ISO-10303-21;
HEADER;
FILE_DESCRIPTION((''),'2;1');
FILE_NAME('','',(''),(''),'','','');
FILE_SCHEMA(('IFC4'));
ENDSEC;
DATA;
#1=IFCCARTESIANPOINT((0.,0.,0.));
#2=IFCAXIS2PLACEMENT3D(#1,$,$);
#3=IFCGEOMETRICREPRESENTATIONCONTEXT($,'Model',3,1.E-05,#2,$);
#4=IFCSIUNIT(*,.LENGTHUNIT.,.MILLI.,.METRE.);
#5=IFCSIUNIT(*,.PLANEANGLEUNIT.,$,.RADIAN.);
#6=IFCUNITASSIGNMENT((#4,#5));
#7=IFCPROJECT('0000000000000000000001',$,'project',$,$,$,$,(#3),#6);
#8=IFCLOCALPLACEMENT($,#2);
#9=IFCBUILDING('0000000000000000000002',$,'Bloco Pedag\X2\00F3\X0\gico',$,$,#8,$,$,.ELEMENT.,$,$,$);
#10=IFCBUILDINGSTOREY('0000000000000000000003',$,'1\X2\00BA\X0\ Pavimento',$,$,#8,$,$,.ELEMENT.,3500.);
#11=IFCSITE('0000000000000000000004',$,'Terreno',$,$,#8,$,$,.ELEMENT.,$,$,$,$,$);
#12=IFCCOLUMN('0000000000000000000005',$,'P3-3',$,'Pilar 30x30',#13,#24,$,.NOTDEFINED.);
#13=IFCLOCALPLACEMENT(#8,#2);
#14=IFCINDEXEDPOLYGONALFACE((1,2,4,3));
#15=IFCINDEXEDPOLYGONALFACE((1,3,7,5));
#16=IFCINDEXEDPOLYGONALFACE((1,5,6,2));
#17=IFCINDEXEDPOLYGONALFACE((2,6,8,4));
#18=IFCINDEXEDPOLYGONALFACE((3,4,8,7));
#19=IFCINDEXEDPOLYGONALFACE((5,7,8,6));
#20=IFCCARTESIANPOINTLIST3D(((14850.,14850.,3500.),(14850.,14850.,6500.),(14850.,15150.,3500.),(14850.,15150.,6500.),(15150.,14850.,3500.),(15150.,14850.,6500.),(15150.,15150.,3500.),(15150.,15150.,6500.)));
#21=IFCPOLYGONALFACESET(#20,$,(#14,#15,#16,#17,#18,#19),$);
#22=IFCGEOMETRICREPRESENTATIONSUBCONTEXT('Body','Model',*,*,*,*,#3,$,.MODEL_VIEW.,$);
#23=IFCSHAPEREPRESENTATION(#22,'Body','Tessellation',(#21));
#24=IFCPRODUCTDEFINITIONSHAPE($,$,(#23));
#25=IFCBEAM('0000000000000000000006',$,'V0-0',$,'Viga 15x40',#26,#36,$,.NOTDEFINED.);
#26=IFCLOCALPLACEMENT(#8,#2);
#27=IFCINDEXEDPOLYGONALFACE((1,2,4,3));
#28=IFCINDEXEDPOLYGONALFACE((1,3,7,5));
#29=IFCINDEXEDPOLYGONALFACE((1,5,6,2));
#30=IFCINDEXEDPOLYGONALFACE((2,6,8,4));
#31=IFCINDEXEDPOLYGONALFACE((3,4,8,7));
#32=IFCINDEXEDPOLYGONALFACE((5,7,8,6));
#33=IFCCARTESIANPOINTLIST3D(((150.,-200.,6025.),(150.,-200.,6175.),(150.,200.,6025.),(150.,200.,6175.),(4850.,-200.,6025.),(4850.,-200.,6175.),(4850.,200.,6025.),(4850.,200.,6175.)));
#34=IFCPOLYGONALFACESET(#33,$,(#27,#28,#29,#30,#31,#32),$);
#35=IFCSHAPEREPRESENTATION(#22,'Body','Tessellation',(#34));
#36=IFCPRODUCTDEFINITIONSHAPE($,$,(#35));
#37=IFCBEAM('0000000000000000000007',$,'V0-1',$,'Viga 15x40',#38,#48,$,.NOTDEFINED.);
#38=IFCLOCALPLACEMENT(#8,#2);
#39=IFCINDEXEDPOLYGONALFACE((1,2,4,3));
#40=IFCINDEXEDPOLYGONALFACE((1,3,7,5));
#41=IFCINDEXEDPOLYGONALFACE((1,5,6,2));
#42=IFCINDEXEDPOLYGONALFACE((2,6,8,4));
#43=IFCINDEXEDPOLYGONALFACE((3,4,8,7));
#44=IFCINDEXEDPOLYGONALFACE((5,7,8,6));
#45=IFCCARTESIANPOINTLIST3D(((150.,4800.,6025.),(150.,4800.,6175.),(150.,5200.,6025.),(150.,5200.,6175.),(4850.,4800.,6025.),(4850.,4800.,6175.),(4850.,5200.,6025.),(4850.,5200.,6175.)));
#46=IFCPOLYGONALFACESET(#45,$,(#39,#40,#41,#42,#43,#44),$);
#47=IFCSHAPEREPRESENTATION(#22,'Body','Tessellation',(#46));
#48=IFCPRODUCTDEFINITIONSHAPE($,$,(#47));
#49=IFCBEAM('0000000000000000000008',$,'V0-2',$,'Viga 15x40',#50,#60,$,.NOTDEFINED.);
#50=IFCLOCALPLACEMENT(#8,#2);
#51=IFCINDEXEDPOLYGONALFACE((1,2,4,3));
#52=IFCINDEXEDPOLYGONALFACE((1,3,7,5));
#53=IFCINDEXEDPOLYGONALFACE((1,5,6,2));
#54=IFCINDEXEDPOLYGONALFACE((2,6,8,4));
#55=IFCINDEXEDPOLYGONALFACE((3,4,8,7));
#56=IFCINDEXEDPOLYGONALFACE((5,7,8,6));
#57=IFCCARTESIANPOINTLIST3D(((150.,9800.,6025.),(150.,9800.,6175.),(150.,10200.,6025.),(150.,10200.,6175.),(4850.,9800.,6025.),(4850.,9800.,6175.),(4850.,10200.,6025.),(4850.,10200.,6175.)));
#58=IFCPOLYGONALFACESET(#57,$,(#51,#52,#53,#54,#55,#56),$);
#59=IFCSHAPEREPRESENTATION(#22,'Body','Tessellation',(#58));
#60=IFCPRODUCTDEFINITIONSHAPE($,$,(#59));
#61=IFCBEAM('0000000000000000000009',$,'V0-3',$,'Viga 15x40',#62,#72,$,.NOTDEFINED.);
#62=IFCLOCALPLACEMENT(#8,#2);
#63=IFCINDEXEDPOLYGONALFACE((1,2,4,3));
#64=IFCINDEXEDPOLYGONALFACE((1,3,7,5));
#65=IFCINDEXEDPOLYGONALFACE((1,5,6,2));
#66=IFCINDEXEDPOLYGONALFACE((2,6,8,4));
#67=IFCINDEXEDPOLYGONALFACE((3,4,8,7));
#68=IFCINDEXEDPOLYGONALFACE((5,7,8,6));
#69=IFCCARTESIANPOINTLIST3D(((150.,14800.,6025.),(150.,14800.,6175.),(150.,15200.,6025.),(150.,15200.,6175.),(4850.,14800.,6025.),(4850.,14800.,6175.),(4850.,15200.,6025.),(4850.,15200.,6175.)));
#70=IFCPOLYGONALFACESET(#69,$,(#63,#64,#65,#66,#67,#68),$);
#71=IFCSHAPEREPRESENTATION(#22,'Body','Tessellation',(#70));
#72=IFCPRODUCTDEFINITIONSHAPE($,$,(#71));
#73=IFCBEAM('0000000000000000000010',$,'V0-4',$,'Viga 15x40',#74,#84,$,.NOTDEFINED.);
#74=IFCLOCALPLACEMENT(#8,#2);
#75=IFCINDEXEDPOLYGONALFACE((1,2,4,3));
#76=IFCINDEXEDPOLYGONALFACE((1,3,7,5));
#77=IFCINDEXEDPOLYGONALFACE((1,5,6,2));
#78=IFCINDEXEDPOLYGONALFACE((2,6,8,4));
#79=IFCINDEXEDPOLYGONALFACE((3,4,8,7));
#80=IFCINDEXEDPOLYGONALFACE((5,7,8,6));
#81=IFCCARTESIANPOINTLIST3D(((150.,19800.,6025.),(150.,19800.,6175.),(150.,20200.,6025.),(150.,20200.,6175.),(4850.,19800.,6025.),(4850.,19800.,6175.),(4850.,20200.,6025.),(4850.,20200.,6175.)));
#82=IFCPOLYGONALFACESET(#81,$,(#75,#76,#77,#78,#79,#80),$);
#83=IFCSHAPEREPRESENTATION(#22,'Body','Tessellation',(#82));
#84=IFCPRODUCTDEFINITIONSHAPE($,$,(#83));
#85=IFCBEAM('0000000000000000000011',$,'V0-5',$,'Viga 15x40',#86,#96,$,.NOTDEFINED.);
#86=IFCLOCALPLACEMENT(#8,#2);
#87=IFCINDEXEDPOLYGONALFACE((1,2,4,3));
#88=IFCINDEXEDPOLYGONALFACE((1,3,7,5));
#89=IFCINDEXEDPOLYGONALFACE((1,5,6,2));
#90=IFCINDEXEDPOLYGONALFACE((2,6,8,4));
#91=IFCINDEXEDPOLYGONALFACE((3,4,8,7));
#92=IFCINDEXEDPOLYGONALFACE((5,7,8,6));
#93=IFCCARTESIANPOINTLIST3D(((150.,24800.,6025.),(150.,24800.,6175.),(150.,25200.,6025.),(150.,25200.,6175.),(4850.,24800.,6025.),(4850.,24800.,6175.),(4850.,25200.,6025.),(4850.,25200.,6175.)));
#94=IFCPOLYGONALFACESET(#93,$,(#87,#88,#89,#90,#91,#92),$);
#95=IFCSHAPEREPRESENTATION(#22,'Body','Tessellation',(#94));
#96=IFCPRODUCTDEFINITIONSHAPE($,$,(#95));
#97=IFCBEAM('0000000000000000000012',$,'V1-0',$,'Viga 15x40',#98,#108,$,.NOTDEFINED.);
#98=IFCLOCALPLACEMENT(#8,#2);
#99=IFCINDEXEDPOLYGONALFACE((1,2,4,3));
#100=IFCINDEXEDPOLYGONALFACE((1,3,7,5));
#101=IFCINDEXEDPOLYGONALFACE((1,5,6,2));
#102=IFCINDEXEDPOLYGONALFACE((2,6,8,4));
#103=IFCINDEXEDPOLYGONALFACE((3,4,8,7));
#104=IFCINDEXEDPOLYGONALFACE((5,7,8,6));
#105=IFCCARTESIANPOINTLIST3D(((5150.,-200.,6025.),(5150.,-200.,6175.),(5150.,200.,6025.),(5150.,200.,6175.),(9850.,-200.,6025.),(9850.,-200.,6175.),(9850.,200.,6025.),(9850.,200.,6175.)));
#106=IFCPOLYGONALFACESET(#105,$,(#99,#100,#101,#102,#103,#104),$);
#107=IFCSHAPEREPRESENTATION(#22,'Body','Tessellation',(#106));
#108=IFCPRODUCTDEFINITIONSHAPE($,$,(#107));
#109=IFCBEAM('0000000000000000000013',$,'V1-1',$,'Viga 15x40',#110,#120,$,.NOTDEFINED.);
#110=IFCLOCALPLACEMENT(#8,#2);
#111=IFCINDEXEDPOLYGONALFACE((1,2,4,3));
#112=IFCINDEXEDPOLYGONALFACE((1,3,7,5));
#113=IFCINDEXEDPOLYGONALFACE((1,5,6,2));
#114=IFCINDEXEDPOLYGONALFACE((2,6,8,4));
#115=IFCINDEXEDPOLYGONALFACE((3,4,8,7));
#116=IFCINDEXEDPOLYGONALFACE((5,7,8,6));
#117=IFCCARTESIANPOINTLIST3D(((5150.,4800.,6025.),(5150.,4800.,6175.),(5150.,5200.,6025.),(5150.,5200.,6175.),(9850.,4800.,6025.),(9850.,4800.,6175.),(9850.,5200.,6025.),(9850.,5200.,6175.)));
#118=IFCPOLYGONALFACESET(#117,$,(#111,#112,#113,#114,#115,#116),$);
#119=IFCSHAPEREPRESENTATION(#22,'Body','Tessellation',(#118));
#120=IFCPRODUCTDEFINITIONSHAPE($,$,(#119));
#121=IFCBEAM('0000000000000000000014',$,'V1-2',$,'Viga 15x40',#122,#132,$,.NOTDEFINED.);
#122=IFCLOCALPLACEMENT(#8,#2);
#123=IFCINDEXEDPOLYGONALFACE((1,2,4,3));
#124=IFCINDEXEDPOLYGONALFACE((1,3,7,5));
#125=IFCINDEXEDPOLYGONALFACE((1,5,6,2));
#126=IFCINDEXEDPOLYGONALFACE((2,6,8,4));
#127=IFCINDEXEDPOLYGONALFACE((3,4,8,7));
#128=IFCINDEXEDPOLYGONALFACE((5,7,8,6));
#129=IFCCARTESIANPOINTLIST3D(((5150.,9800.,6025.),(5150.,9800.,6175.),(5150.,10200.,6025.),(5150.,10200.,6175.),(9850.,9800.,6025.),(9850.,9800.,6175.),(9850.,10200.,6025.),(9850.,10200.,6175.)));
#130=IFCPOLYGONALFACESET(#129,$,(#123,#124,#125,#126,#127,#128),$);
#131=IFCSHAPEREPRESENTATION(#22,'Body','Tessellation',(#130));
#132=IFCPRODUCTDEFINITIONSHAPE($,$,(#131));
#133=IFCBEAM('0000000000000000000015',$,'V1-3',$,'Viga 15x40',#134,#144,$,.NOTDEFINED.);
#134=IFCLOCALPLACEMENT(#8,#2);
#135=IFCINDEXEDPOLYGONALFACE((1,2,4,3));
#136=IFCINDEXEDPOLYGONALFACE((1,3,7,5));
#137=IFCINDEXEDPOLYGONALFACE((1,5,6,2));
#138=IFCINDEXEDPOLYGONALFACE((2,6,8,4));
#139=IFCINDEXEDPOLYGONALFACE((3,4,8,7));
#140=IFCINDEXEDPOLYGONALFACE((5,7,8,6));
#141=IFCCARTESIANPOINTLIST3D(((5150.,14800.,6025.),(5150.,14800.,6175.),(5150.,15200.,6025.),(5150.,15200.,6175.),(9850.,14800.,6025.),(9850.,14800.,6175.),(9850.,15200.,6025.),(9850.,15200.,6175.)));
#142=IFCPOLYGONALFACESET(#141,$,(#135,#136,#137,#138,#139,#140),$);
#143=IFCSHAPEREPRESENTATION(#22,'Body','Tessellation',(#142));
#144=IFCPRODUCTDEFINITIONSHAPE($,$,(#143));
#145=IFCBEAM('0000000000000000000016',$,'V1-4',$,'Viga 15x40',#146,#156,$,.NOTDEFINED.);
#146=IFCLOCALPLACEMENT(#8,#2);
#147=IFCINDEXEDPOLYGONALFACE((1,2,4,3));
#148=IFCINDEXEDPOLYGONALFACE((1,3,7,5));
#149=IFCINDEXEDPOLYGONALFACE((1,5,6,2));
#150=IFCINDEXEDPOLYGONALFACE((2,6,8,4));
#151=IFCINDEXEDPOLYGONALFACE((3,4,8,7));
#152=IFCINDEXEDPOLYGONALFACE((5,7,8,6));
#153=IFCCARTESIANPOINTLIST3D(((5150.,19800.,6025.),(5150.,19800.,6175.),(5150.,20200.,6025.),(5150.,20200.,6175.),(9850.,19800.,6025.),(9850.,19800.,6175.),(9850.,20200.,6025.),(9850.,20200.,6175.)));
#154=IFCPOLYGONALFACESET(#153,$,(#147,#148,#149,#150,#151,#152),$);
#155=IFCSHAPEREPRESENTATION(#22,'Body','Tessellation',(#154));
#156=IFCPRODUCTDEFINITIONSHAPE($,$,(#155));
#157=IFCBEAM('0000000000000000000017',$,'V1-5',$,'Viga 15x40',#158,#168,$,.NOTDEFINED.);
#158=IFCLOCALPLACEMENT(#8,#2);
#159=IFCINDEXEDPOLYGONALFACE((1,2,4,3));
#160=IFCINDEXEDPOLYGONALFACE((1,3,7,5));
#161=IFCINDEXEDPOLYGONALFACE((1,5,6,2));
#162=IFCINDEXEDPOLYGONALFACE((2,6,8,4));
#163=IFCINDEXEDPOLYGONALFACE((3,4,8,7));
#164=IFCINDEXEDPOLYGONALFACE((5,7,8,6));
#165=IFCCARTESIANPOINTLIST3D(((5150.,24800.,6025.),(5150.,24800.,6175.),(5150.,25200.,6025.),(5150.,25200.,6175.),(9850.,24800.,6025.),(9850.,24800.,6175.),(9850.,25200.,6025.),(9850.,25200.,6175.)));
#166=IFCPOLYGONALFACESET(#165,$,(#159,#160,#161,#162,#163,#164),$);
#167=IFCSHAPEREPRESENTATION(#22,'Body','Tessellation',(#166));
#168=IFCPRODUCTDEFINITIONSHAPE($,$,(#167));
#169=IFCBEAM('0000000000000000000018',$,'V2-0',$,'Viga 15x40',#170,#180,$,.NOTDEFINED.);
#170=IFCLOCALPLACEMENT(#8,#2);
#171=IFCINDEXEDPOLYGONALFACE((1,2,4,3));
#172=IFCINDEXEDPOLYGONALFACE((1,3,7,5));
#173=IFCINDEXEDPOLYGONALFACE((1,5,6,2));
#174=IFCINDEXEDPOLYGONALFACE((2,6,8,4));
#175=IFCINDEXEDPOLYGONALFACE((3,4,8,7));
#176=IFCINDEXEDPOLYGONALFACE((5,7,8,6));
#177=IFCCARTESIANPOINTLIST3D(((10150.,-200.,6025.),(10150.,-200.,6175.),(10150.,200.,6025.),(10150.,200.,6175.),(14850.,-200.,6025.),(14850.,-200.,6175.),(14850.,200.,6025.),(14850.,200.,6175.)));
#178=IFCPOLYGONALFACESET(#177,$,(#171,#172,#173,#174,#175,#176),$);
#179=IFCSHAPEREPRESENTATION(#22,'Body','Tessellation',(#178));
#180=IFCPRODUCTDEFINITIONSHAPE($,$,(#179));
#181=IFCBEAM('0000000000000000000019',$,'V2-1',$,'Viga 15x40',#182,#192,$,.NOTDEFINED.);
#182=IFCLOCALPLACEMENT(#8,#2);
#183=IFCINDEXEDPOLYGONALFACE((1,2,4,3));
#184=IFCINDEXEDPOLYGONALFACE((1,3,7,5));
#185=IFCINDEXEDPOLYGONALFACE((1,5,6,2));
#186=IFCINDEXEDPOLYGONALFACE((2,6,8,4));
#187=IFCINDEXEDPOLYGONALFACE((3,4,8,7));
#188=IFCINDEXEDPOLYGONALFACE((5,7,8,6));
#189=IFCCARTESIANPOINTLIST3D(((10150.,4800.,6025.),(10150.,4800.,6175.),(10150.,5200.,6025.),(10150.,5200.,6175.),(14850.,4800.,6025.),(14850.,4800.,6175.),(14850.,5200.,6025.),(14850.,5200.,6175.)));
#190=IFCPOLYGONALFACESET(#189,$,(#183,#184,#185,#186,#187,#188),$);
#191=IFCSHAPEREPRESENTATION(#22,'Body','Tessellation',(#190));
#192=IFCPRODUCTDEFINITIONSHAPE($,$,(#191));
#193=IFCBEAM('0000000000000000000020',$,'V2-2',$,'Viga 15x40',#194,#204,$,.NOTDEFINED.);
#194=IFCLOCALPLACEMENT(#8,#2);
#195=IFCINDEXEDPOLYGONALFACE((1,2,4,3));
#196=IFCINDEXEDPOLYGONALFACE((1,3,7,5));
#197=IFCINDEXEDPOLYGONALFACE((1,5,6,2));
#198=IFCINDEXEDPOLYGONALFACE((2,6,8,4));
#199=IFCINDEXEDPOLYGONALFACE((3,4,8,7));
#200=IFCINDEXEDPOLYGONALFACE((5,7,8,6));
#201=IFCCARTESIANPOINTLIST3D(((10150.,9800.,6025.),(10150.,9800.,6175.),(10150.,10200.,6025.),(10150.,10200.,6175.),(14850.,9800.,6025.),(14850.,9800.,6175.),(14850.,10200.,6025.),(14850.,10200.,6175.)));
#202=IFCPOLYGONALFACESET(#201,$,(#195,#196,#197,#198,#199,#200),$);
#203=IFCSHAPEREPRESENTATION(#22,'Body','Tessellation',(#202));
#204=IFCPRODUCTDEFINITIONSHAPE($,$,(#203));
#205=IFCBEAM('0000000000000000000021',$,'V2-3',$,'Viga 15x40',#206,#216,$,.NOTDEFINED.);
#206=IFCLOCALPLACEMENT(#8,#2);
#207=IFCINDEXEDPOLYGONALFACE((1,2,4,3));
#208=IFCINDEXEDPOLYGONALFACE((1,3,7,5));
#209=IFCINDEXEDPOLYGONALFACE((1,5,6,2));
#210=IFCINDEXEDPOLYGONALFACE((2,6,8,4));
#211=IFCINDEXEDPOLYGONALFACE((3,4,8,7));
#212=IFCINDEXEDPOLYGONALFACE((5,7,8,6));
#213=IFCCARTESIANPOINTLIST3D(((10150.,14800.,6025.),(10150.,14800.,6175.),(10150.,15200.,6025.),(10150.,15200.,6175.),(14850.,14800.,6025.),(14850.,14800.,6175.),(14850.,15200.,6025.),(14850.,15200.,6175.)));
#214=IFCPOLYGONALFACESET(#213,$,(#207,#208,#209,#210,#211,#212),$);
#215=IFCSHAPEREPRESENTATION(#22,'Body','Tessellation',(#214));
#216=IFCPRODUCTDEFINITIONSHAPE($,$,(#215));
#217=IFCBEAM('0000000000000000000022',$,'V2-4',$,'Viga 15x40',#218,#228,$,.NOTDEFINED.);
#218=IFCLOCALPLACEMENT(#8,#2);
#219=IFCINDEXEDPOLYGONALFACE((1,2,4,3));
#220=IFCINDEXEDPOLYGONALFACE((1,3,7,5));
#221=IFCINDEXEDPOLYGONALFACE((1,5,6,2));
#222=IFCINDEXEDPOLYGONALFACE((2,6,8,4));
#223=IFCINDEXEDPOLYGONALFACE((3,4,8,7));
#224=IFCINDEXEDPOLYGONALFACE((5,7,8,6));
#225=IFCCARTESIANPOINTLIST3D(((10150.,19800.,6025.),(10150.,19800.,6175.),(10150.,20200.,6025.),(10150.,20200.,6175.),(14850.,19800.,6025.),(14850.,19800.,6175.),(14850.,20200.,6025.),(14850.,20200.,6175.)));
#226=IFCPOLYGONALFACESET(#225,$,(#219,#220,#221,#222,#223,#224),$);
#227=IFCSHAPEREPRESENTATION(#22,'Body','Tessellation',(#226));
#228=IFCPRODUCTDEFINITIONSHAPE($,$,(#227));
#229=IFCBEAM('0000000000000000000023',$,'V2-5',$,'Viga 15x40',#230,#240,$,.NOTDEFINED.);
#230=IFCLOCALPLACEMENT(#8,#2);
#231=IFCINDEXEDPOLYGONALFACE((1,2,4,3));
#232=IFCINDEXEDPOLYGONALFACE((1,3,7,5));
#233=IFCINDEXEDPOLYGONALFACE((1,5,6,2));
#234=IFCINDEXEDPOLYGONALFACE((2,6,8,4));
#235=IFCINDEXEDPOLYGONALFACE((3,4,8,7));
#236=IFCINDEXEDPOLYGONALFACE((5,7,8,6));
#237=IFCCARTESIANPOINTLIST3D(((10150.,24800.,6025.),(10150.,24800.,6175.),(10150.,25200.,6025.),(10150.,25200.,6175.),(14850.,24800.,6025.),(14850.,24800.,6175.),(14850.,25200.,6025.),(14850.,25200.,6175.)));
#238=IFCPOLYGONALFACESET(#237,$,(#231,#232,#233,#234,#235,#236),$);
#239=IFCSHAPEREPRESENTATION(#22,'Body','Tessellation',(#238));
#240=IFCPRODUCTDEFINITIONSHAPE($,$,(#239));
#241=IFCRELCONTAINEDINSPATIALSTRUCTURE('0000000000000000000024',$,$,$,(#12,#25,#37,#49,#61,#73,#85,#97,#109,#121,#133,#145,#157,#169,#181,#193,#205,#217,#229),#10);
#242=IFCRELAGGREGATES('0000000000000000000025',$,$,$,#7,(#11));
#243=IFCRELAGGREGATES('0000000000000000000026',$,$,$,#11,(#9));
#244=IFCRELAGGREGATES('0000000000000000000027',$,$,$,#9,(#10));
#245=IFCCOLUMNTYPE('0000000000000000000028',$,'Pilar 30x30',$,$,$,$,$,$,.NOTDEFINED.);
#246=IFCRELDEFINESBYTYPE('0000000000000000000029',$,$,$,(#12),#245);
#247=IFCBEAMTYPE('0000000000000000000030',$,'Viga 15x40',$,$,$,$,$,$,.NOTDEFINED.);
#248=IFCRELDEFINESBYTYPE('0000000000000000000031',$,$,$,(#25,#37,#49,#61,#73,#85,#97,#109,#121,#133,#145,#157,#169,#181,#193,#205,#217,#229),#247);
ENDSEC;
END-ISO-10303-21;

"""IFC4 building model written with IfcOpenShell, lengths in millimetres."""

from ifc_helpers import new_model, si_unit, frame, origin, origin_2d, place, context, subcontext, project, spatial, rectangle, extrude, type_object, element, save


model = new_model("IFC4")

# Units and contexts
model_context = context("Model", 3, precision=1e-05, world=origin())
body_context = subcontext(model_context, "Body", "Model", "MODEL_VIEW")
ifc_project = project(units=[si_unit("LENGTHUNIT", "METRE", prefix="MILLI"), si_unit("PLANEANGLEUNIT", "RADIAN")], contexts=[model_context])

# Site, building, storey
placement = place(None, origin())
site = spatial("IfcSite", under=ifc_project, at=placement, Name="Terreno", CompositionType="ELEMENT")
building = spatial("IfcBuilding", under=site, at=placement, Name="Bloco Pedagógico", CompositionType="ELEMENT")
storey = spatial("IfcBuildingStorey", under=building, at=placement, Name="1º Pavimento", CompositionType="ELEMENT", Elevation=3500.0)

# Column
column_type = type_object("IfcColumnType", Name="Pilar 30x30", PredefinedType="NOTDEFINED")
for number, where, z_axis, x_axis, name in (
    (1, (15000.0, 15000.0, 3500.0), (0.0, 0.0, 1.0), (1.0, 0.0, 0.0), "P3-3"),
):
    element("IfcColumn", number, at=place(None, frame(where, z_axis=z_axis, x_axis=x_axis)), inside=storey, type_object=column_type, Name=name, ObjectType="Pilar 30x30", PredefinedType="NOTDEFINED", context=body_context, shape_type="SweptSolid", body=[
        extrude(rectangle(XDim=300.0, YDim=300.0, at=origin_2d()), None, (0.0, 0.0, 1.0), 3000.0),
    ])

# Beams
beam_type = type_object("IfcBeamType", Name="Viga 15x40", PredefinedType="NOTDEFINED")
for number, where, z_axis, x_axis, name in (
    (2, (150.0, 0.0, 6100.0), (1.0, 0.0, 0.0), (0.0, 1.0, 0.0), "V0-0"),
    (3, (150.0, 5000.0, 6100.0), (1.0, 0.0, 0.0), (0.0, 1.0, 0.0), "V0-1"),
    (4, (150.0, 10000.0, 6100.0), (1.0, 0.0, 0.0), (0.0, 1.0, 0.0), "V0-2"),
    (5, (150.0, 15000.0, 6100.0), (1.0, 0.0, 0.0), (0.0, 1.0, 0.0), "V0-3"),
    (6, (150.0, 20000.0, 6100.0), (1.0, 0.0, 0.0), (0.0, 1.0, 0.0), "V0-4"),
    (7, (150.0, 25000.0, 6100.0), (1.0, 0.0, 0.0), (0.0, 1.0, 0.0), "V0-5"),
    (8, (5150.0, 0.0, 6100.0), (1.0, 0.0, 0.0), (0.0, 1.0, 0.0), "V1-0"),
    (9, (5150.0, 5000.0, 6100.0), (1.0, 0.0, 0.0), (0.0, 1.0, 0.0), "V1-1"),
    (10, (5150.0, 10000.0, 6100.0), (1.0, 0.0, 0.0), (0.0, 1.0, 0.0), "V1-2"),
    (11, (5150.0, 15000.0, 6100.0), (1.0, 0.0, 0.0), (0.0, 1.0, 0.0), "V1-3"),
    (12, (5150.0, 20000.0, 6100.0), (1.0, 0.0, 0.0), (0.0, 1.0, 0.0), "V1-4"),
    (13, (5150.0, 25000.0, 6100.0), (1.0, 0.0, 0.0), (0.0, 1.0, 0.0), "V1-5"),
    (14, (10150.0, 0.0, 6100.0), (1.0, 0.0, 0.0), (0.0, 1.0, 0.0), "V2-0"),
    (15, (10150.0, 5000.0, 6100.0), (1.0, 0.0, 0.0), (0.0, 1.0, 0.0), "V2-1"),
    (16, (10150.0, 10000.0, 6100.0), (1.0, 0.0, 0.0), (0.0, 1.0, 0.0), "V2-2"),
    (17, (10150.0, 15000.0, 6100.0), (1.0, 0.0, 0.0), (0.0, 1.0, 0.0), "V2-3"),
    (18, (10150.0, 20000.0, 6100.0), (1.0, 0.0, 0.0), (0.0, 1.0, 0.0), "V2-4"),
    (19, (10150.0, 25000.0, 6100.0), (1.0, 0.0, 0.0), (0.0, 1.0, 0.0), "V2-5"),
):
    element("IfcBeam", number, at=place(None, frame(where, z_axis=z_axis, x_axis=x_axis)), inside=storey, type_object=beam_type, Name=name, ObjectType="Viga 15x40", PredefinedType="NOTDEFINED", context=body_context, shape_type="SweptSolid", body=[
        extrude(rectangle(XDim=400.0, YDim=150.0, at=origin_2d()), None, (0.0, 0.0, 1.0), 4700.0),
    ])

save(model, "model.ifc")
